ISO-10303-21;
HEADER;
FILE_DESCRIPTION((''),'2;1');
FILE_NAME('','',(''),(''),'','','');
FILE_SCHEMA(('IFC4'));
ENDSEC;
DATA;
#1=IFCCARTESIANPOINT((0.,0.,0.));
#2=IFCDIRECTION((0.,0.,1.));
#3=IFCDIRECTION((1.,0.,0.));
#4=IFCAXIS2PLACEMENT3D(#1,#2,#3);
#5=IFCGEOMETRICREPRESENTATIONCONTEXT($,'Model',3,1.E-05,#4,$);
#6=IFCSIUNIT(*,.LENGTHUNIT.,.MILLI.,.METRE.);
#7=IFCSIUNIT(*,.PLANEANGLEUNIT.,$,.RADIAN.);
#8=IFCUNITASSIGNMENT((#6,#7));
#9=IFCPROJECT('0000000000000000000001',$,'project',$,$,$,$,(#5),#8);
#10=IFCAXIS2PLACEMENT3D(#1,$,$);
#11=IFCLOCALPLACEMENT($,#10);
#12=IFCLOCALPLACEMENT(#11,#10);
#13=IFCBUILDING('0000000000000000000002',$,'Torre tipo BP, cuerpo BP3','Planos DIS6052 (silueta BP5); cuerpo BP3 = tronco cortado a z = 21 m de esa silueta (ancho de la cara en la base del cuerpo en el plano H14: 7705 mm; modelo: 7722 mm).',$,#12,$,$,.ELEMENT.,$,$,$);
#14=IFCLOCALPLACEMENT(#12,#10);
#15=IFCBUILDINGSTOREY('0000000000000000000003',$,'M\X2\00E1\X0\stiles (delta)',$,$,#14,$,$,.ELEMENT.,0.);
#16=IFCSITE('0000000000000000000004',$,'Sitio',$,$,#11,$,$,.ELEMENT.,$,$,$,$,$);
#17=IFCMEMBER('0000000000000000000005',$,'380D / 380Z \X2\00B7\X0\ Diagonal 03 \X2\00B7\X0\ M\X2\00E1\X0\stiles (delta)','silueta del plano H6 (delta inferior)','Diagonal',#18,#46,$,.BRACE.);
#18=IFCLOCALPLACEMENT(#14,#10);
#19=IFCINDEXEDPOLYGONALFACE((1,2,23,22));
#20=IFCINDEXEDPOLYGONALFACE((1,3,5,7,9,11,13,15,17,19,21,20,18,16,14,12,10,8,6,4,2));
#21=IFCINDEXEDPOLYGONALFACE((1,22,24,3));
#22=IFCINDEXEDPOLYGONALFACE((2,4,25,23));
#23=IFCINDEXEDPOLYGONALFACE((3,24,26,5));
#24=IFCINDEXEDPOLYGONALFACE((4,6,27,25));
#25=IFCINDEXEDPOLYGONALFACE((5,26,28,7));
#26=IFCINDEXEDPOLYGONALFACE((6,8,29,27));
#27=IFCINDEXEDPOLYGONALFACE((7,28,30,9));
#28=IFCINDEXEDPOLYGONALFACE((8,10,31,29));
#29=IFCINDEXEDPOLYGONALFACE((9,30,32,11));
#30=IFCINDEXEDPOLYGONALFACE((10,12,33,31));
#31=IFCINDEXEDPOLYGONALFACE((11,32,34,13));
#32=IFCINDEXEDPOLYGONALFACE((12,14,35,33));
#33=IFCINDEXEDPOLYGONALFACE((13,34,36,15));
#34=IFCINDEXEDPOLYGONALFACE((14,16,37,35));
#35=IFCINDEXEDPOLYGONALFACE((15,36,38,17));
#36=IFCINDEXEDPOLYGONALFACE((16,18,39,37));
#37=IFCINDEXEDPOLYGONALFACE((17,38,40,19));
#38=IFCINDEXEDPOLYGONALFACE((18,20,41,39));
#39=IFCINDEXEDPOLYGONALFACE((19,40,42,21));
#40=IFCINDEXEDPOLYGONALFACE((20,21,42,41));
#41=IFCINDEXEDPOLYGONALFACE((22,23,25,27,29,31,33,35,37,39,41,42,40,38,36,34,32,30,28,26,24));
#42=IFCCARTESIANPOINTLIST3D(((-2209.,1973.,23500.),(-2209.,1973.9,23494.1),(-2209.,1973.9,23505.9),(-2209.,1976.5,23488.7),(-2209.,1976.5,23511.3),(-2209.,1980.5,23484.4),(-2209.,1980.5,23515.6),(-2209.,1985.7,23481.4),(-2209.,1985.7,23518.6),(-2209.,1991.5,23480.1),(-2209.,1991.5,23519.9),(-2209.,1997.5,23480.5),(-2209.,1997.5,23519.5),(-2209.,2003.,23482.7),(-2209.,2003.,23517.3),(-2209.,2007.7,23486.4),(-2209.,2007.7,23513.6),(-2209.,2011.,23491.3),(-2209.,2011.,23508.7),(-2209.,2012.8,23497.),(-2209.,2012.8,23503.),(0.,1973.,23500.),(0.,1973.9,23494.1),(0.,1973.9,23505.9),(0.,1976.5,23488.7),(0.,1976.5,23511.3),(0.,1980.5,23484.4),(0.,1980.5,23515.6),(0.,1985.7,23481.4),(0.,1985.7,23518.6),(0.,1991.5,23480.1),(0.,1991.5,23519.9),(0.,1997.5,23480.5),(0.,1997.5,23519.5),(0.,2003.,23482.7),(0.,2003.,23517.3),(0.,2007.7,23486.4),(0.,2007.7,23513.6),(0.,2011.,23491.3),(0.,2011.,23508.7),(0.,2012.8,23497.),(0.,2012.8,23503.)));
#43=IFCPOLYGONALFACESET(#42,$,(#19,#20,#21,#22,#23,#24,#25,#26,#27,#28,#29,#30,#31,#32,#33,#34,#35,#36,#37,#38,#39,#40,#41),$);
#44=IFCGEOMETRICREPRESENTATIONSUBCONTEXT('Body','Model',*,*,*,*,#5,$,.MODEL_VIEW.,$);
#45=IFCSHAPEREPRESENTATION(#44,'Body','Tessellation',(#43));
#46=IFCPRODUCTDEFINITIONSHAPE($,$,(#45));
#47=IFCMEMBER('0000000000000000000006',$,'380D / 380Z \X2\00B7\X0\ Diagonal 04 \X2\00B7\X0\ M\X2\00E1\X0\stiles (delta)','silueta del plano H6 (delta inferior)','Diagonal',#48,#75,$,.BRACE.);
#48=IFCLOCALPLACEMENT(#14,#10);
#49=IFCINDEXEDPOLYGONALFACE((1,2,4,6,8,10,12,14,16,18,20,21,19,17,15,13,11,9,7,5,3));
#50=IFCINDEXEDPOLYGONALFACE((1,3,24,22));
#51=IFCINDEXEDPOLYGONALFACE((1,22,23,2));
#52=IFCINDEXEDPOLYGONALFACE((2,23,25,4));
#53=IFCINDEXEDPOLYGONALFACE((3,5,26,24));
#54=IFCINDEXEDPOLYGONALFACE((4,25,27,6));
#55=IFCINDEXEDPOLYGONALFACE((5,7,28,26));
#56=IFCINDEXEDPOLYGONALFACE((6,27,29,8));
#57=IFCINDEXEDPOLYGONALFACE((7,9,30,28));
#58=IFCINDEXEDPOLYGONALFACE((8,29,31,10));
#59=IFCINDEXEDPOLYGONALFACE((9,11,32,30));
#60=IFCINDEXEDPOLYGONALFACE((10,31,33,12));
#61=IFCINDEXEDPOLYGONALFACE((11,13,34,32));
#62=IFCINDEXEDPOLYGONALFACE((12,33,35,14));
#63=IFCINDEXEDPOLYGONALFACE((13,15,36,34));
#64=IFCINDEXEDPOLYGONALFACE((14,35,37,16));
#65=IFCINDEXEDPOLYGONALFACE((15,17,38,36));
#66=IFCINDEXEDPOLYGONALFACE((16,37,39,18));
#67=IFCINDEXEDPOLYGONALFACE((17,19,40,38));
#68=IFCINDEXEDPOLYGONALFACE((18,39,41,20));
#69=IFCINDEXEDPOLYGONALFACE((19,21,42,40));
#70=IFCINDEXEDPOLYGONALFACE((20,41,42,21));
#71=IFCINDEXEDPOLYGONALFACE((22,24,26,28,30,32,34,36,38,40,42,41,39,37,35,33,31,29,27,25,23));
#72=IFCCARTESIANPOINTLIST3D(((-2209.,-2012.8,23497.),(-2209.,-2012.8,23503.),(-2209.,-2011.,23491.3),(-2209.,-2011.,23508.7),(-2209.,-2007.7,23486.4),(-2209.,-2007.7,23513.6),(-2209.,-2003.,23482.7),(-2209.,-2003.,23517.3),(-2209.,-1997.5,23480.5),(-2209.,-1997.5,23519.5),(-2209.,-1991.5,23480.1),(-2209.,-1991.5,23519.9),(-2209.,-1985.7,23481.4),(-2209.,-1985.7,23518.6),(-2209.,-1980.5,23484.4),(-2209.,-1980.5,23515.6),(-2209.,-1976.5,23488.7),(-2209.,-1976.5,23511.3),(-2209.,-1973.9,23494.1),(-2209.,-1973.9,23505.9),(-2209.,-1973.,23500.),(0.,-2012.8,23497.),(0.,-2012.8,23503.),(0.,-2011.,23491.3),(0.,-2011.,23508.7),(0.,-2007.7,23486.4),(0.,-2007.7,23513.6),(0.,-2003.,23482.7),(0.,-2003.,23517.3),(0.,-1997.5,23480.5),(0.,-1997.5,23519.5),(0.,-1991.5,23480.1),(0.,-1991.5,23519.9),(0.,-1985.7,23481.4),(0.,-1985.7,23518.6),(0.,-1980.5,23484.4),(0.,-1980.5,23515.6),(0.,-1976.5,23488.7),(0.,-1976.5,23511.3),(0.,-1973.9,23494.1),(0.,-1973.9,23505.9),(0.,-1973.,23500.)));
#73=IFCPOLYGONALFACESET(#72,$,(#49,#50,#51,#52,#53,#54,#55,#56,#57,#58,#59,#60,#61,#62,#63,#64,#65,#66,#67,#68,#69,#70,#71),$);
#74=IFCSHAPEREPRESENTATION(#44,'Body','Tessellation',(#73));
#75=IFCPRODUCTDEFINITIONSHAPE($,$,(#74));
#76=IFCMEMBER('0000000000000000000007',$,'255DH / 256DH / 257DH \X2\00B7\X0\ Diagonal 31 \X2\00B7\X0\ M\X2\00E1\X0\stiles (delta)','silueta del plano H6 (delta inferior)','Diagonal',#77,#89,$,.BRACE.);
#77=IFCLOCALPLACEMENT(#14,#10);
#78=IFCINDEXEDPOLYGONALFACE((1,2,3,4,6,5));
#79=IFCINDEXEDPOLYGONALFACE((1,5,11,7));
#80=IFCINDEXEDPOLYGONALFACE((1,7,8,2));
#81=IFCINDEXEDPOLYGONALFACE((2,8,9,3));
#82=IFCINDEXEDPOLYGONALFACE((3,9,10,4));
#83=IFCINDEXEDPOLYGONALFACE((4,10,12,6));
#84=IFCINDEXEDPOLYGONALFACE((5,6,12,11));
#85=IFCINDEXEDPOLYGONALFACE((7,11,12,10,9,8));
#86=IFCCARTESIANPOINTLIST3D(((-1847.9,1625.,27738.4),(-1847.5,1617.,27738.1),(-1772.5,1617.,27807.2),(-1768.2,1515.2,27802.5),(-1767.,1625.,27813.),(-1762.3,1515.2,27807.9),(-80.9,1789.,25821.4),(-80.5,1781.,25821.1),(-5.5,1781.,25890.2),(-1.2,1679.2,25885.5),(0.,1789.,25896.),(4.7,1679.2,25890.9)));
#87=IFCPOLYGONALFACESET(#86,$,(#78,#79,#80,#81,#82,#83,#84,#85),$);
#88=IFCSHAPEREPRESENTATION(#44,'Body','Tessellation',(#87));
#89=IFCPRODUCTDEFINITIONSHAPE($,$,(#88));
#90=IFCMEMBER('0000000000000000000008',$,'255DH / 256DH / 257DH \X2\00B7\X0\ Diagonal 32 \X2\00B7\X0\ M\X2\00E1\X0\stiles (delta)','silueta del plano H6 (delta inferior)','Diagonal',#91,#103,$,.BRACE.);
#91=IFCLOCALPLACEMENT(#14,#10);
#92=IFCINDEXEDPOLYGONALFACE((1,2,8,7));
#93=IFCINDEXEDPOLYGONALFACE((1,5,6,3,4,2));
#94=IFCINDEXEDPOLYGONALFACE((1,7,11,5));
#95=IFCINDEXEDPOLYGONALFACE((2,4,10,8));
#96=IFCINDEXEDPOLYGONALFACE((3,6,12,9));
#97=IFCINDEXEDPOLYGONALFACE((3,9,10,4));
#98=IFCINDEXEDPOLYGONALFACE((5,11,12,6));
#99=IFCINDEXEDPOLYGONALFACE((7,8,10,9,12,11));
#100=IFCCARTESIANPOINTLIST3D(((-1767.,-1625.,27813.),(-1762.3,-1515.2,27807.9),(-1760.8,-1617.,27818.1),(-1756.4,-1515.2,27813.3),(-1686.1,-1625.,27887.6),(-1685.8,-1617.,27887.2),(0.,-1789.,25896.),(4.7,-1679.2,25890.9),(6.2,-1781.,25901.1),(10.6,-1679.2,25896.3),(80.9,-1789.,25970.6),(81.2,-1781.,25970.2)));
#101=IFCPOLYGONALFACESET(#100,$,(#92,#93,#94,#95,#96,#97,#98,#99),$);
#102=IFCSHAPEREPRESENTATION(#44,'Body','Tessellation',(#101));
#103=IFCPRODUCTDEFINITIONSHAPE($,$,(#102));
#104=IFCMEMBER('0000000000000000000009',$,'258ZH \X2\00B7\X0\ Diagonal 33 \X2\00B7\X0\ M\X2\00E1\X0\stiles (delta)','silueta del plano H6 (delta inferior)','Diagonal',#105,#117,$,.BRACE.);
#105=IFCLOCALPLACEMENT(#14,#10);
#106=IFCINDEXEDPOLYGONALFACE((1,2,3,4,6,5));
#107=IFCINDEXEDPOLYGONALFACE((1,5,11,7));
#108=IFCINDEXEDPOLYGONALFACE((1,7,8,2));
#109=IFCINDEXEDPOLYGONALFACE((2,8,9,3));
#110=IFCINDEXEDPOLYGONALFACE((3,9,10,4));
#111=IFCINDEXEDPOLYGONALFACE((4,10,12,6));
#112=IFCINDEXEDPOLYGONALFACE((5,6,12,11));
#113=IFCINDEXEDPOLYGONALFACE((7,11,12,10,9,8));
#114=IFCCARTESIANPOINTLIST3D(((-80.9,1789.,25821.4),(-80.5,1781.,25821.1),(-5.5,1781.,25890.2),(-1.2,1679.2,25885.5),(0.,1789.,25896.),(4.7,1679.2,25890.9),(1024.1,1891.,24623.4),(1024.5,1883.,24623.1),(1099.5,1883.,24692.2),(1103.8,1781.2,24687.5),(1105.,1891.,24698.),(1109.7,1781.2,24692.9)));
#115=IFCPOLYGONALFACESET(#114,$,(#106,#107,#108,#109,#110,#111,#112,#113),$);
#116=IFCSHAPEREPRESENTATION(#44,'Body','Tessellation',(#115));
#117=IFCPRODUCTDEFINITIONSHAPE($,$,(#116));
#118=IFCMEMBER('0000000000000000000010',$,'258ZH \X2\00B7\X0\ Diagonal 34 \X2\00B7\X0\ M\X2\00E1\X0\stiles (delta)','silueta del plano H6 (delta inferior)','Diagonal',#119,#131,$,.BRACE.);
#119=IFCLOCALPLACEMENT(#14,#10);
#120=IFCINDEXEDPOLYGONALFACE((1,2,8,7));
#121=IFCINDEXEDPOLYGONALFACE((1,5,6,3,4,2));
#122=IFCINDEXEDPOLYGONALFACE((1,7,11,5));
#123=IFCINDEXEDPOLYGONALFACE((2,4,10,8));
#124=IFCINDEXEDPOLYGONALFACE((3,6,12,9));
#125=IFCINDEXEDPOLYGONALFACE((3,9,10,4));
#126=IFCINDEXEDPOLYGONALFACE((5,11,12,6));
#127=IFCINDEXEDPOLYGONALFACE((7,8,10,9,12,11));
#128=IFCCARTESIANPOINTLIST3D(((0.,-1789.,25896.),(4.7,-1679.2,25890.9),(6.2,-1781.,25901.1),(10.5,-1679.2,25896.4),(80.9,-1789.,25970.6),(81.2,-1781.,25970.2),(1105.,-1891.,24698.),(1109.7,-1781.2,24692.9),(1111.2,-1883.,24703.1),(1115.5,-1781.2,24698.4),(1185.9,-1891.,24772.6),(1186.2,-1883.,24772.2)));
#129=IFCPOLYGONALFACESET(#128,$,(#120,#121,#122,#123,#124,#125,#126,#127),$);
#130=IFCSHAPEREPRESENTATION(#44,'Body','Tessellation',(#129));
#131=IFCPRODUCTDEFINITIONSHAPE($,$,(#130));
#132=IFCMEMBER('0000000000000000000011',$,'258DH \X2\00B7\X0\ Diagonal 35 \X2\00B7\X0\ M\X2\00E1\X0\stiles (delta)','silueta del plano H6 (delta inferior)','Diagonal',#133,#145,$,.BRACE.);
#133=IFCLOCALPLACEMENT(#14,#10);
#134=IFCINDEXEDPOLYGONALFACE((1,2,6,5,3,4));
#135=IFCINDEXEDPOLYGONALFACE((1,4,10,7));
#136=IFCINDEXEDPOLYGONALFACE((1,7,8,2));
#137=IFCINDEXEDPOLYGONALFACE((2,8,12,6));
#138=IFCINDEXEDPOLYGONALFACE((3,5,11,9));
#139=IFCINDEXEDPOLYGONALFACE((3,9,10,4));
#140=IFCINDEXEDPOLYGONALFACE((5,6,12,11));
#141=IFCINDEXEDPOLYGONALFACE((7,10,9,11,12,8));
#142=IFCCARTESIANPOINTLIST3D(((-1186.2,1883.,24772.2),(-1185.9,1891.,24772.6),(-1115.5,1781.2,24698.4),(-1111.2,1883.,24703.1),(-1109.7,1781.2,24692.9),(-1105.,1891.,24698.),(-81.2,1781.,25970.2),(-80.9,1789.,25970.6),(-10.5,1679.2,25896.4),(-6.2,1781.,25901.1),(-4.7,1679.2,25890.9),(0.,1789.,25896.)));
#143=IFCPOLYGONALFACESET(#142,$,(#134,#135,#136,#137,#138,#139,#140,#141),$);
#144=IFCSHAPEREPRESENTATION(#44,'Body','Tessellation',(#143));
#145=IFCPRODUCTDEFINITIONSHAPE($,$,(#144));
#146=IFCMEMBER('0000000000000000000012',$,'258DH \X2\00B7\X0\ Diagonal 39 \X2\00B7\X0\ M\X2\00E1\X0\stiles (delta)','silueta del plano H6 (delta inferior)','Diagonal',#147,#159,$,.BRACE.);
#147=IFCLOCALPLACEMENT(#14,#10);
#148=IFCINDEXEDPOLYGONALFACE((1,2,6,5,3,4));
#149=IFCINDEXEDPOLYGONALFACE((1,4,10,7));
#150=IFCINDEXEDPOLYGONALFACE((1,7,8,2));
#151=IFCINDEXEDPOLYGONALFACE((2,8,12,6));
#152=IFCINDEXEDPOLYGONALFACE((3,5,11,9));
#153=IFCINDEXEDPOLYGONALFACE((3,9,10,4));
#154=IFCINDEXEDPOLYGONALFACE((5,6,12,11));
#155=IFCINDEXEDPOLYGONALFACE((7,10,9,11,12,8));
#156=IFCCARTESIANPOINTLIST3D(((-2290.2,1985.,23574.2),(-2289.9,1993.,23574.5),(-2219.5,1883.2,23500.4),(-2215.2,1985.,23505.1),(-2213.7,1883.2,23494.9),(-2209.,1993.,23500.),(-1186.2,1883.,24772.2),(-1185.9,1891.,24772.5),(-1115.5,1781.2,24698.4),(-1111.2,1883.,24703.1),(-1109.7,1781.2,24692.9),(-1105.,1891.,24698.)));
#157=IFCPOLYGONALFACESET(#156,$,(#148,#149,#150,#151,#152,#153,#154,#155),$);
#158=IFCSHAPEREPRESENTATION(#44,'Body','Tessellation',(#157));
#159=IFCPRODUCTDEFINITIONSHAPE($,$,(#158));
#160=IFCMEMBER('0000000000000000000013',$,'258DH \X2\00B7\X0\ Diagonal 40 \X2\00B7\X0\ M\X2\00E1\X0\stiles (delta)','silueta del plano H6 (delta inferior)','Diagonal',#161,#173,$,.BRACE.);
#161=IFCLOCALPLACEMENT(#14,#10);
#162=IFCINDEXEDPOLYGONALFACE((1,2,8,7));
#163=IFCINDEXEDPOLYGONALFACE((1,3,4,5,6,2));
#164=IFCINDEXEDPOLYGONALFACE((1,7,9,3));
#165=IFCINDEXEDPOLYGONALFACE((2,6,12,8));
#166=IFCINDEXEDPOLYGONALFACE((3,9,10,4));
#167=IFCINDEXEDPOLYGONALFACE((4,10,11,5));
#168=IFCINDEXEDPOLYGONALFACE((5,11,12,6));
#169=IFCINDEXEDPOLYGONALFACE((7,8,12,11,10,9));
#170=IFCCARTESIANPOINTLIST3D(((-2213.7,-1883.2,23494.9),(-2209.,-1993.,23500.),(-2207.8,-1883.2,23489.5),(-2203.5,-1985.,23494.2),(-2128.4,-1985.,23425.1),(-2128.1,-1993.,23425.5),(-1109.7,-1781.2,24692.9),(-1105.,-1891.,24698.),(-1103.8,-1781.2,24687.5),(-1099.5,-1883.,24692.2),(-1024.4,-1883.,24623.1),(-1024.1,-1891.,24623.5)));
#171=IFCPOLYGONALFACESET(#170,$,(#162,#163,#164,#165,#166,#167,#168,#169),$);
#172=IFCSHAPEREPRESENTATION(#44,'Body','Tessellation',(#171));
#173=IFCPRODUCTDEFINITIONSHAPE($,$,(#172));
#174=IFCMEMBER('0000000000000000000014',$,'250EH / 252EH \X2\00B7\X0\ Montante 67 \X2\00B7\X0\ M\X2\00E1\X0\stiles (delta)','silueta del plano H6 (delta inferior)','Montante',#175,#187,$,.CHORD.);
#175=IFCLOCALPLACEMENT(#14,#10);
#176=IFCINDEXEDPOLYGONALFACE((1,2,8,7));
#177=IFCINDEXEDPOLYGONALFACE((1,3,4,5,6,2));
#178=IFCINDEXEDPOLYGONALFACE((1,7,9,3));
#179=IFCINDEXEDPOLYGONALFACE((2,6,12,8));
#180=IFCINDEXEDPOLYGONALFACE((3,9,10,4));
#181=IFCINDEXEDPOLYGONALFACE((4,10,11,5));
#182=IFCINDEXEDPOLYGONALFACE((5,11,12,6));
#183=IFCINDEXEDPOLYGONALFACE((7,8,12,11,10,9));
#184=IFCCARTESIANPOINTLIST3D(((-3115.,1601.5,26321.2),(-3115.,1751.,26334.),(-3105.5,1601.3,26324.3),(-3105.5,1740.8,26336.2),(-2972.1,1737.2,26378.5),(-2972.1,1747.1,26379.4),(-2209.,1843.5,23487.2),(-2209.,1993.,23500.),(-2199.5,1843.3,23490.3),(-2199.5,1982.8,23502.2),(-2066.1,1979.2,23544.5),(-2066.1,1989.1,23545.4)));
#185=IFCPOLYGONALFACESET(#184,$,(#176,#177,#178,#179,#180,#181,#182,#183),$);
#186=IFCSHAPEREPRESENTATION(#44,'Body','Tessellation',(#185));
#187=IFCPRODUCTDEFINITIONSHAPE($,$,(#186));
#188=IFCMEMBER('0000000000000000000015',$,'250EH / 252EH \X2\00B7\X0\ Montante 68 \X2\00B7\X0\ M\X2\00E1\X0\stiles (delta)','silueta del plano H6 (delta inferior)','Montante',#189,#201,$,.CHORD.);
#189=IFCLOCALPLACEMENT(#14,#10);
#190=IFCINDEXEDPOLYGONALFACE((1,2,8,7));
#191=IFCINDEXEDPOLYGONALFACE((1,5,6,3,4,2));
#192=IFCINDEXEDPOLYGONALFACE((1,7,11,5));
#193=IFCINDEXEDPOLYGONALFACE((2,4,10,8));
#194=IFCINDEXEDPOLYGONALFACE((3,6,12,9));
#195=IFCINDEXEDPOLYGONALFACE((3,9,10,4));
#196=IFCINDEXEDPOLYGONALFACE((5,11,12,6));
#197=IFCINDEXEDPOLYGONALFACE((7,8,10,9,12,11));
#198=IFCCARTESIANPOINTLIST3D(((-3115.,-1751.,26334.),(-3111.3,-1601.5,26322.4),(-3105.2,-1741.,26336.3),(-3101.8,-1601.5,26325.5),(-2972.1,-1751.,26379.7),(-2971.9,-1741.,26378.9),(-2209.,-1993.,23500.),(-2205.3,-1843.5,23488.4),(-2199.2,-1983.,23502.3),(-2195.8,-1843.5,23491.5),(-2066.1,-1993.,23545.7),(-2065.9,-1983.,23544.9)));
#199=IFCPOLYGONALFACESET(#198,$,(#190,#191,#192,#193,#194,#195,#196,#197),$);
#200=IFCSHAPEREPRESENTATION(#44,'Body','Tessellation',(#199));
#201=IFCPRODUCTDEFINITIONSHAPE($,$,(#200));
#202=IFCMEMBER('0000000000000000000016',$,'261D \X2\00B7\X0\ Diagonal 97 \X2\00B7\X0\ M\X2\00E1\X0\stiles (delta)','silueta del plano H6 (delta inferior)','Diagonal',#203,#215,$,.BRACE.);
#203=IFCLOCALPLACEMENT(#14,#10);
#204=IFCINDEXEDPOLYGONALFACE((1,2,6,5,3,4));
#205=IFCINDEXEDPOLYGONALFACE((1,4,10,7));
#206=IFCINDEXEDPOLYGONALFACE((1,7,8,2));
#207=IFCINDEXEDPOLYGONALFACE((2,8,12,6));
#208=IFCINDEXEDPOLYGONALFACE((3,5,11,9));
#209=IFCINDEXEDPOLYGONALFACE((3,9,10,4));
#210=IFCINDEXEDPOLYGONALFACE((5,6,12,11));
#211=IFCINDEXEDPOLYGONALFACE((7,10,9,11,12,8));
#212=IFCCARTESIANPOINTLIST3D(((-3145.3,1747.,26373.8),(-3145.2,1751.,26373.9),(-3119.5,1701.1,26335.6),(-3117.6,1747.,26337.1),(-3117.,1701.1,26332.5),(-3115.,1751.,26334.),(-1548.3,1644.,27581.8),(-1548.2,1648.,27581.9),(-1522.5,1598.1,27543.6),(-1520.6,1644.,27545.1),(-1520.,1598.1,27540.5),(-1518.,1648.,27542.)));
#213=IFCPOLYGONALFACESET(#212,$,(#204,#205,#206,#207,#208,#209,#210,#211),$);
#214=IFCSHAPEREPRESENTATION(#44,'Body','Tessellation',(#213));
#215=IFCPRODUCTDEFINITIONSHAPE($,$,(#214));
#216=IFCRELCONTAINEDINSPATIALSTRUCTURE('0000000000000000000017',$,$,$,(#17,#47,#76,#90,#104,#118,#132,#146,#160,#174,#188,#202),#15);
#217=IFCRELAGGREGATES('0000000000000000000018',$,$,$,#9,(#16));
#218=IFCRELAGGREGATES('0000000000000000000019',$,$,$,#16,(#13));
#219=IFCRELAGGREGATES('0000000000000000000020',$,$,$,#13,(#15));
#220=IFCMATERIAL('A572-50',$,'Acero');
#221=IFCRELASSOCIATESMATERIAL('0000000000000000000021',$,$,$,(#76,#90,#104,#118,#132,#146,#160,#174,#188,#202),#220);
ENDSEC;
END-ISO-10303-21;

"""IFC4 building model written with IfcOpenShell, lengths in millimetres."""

from ifc_helpers import new_model, si_unit, frame, frame_2d, origin, origin_with_axes, place, context, subcontext, project, spatial, circle, l_section, extrude, material, element, save


model = new_model("IFC4")

# Units and contexts
model_context = context("Model", 3, precision=1e-05, world=origin_with_axes())
body_context = subcontext(model_context, "Body", "Model", "MODEL_VIEW")
ifc_project = project(units=[si_unit("LENGTHUNIT", "METRE", prefix="MILLI"), si_unit("PLANEANGLEUNIT", "RADIAN")], contexts=[model_context])

# Site, building, storey
site_placement = place(None, origin())
site = spatial("IfcSite", under=ifc_project, at=site_placement, Name="Sitio", CompositionType="ELEMENT")
building_placement = place(site_placement, origin())
building = spatial("IfcBuilding", under=site, at=building_placement, Name="Torre tipo BP, cuerpo BP3", Description="Planos DIS6052 (silueta BP5); cuerpo BP3 = tronco cortado a z = 21 m de esa silueta (ancho de la cara en la base del cuerpo en el plano H14: 7705 mm; modelo: 7722 mm).", CompositionType="ELEMENT")
storey_placement = place(building_placement, origin())
storey = spatial("IfcBuildingStorey", under=building, at=storey_placement, Name="Mástiles (delta)", CompositionType="ELEMENT", Elevation=0.0)

# Members
for number, where, z_axis, x_axis, name in (
    (1, (-2209.0, 1993.0, 23500.0), (1.0, 0.0, 0.0), (0.0, -1.0, 0.0), "380D / 380Z · Diagonal 03 · Mástiles (delta)"),
    (2, (-2209.0, -1993.0, 23500.0), (1.0, 0.0, 0.0), (0.0, 1.0, 0.0), "380D / 380Z · Diagonal 04 · Mástiles (delta)"),
):
    element("IfcMember", number, at=place(storey_placement, frame(where, z_axis=z_axis, x_axis=x_axis)), inside=storey, Name=name, Description="silueta del plano H6 (delta inferior)", ObjectType="Diagonal", PredefinedType="BRACE", context=body_context, shape_type="SweptSolid", body=[
        extrude(circle(Radius=20.0), None, (0.0, 0.0, 1.0), 2209.0),
    ])
ifc_material = material(Name="A572-50", Category="Acero")
for number, where, z_axis, x_axis, name in (
    (3, (-1767.0, 1625.0, 27813.0), (0.676417, 0.06278, -0.733838), (0.042549, -0.998027, -0.046161), "255DH / 256DH / 257DH · Diagonal 31 · Mástiles (delta)"),
    (4, (-1767.0, -1625.0, 27813.0), (0.676417, -0.06278, -0.733838), (0.042549, 0.998027, -0.046161), "255DH / 256DH / 257DH · Diagonal 32 · Mástiles (delta)"),
):
    element("IfcMember", number, at=place(storey_placement, frame(where, z_axis=z_axis, x_axis=x_axis)), inside=storey, material=ifc_material, Name=name, Description="silueta del plano H6 (delta inferior)", ObjectType="Diagonal", PredefinedType="BRACE", context=body_context, shape_type="SweptSolid", body=[
        extrude(l_section(Depth=110.0, Width=110.0, Thickness=8.0, at=frame_2d((55.0, 55.0))), None, (0.0, 0.0, 1.0), 2612.3),
    ])
for number, where, z_axis, x_axis, name in (
    (5, (0.0, 1789.0, 25896.0), (0.676676, 0.062462, -0.733627), (0.042349, -0.998047, -0.045914), "258ZH · Diagonal 33 · Mástiles (delta)"),
    (6, (0.0, -1789.0, 25896.0), (0.676676, -0.062462, -0.733627), (0.042349, 0.998047, -0.045914), "258ZH · Diagonal 34 · Mástiles (delta)"),
    (7, (0.0, 1789.0, 25896.0), (-0.676676, 0.062462, -0.733627), (-0.042349, -0.998047, -0.045914), "258DH · Diagonal 35 · Mástiles (delta)"),
):
    element("IfcMember", number, at=place(storey_placement, frame(where, z_axis=z_axis, x_axis=x_axis)), inside=storey, material=ifc_material, Name=name, Description="silueta del plano H6 (delta inferior)", ObjectType="Diagonal", PredefinedType="BRACE", context=body_context, shape_type="SweptSolid", body=[
        extrude(l_section(Depth=110.0, Width=110.0, Thickness=8.0, at=frame_2d((55.0, 55.0))), None, (0.0, 0.0, 1.0), 1633.0),
    ])
for number, where, z_axis, x_axis, name in (
    (8, (-1105.0, 1891.0, 24698.0), (-0.676344, 0.062488, -0.733931), (-0.042346, -0.998046, -0.045952), "258DH · Diagonal 39 · Mástiles (delta)"),
    (9, (-1105.0, -1891.0, 24698.0), (-0.676344, -0.062488, -0.733931), (-0.042346, 0.998046, -0.045952), "258DH · Diagonal 40 · Mástiles (delta)"),
):
    element("IfcMember", number, at=place(storey_placement, frame(where, z_axis=z_axis, x_axis=x_axis)), inside=storey, material=ifc_material, Name=name, Description="silueta del plano H6 (delta inferior)", ObjectType="Diagonal", PredefinedType="BRACE", context=body_context, shape_type="SweptSolid", body=[
        extrude(l_section(Depth=110.0, Width=110.0, Thickness=8.0, at=frame_2d((55.0, 55.0))), None, (0.0, 0.0, 1.0), 1632.3),
    ])
for number, where, z_axis, x_axis, name in (
    (10, (-3115.0, 1751.0, 26334.0), (0.303505, 0.081069, -0.949375), (0.95283, -0.025823, 0.302405), "250EH / 252EH · Montante 67 · Mástiles (delta)"),
    (11, (-3115.0, -1751.0, 26334.0), (0.303505, -0.081069, -0.949375), (0.024686, 0.996709, -0.077219), "250EH / 252EH · Montante 68 · Mástiles (delta)"),
):
    element("IfcMember", number, at=place(storey_placement, frame(where, z_axis=z_axis, x_axis=x_axis)), inside=storey, material=ifc_material, Name=name, Description="silueta del plano H6 (delta inferior)", ObjectType="Montante", PredefinedType="CHORD", context=body_context, shape_type="SweptSolid", body=[
        extrude(l_section(Depth=150.0, Width=150.0, Thickness=10.0, at=frame_2d((75.0, 75.0))), None, (0.0, 0.0, 1.0), 2985.1),
    ])
for number, where, z_axis, x_axis, name in (
    (12, (-1518.0, 1648.0, 27542.0), (-0.796483, 0.05137, -0.602475), (-0.040969, -0.99868, -0.03099), "261D · Diagonal 97 · Mástiles (delta)"),
):
    element("IfcMember", number, at=place(storey_placement, frame(where, z_axis=z_axis, x_axis=x_axis)), inside=storey, material=ifc_material, Name=name, Description="silueta del plano H6 (delta inferior)", ObjectType="Diagonal", PredefinedType="BRACE", context=body_context, shape_type="SweptSolid", body=[
        extrude(l_section(Depth=50.0, Width=50.0, Thickness=4.0, at=frame_2d((25.0, 25.0))), None, (0.0, 0.0, 1.0), 2005.1),
    ])

save(model, "model.ifc")
